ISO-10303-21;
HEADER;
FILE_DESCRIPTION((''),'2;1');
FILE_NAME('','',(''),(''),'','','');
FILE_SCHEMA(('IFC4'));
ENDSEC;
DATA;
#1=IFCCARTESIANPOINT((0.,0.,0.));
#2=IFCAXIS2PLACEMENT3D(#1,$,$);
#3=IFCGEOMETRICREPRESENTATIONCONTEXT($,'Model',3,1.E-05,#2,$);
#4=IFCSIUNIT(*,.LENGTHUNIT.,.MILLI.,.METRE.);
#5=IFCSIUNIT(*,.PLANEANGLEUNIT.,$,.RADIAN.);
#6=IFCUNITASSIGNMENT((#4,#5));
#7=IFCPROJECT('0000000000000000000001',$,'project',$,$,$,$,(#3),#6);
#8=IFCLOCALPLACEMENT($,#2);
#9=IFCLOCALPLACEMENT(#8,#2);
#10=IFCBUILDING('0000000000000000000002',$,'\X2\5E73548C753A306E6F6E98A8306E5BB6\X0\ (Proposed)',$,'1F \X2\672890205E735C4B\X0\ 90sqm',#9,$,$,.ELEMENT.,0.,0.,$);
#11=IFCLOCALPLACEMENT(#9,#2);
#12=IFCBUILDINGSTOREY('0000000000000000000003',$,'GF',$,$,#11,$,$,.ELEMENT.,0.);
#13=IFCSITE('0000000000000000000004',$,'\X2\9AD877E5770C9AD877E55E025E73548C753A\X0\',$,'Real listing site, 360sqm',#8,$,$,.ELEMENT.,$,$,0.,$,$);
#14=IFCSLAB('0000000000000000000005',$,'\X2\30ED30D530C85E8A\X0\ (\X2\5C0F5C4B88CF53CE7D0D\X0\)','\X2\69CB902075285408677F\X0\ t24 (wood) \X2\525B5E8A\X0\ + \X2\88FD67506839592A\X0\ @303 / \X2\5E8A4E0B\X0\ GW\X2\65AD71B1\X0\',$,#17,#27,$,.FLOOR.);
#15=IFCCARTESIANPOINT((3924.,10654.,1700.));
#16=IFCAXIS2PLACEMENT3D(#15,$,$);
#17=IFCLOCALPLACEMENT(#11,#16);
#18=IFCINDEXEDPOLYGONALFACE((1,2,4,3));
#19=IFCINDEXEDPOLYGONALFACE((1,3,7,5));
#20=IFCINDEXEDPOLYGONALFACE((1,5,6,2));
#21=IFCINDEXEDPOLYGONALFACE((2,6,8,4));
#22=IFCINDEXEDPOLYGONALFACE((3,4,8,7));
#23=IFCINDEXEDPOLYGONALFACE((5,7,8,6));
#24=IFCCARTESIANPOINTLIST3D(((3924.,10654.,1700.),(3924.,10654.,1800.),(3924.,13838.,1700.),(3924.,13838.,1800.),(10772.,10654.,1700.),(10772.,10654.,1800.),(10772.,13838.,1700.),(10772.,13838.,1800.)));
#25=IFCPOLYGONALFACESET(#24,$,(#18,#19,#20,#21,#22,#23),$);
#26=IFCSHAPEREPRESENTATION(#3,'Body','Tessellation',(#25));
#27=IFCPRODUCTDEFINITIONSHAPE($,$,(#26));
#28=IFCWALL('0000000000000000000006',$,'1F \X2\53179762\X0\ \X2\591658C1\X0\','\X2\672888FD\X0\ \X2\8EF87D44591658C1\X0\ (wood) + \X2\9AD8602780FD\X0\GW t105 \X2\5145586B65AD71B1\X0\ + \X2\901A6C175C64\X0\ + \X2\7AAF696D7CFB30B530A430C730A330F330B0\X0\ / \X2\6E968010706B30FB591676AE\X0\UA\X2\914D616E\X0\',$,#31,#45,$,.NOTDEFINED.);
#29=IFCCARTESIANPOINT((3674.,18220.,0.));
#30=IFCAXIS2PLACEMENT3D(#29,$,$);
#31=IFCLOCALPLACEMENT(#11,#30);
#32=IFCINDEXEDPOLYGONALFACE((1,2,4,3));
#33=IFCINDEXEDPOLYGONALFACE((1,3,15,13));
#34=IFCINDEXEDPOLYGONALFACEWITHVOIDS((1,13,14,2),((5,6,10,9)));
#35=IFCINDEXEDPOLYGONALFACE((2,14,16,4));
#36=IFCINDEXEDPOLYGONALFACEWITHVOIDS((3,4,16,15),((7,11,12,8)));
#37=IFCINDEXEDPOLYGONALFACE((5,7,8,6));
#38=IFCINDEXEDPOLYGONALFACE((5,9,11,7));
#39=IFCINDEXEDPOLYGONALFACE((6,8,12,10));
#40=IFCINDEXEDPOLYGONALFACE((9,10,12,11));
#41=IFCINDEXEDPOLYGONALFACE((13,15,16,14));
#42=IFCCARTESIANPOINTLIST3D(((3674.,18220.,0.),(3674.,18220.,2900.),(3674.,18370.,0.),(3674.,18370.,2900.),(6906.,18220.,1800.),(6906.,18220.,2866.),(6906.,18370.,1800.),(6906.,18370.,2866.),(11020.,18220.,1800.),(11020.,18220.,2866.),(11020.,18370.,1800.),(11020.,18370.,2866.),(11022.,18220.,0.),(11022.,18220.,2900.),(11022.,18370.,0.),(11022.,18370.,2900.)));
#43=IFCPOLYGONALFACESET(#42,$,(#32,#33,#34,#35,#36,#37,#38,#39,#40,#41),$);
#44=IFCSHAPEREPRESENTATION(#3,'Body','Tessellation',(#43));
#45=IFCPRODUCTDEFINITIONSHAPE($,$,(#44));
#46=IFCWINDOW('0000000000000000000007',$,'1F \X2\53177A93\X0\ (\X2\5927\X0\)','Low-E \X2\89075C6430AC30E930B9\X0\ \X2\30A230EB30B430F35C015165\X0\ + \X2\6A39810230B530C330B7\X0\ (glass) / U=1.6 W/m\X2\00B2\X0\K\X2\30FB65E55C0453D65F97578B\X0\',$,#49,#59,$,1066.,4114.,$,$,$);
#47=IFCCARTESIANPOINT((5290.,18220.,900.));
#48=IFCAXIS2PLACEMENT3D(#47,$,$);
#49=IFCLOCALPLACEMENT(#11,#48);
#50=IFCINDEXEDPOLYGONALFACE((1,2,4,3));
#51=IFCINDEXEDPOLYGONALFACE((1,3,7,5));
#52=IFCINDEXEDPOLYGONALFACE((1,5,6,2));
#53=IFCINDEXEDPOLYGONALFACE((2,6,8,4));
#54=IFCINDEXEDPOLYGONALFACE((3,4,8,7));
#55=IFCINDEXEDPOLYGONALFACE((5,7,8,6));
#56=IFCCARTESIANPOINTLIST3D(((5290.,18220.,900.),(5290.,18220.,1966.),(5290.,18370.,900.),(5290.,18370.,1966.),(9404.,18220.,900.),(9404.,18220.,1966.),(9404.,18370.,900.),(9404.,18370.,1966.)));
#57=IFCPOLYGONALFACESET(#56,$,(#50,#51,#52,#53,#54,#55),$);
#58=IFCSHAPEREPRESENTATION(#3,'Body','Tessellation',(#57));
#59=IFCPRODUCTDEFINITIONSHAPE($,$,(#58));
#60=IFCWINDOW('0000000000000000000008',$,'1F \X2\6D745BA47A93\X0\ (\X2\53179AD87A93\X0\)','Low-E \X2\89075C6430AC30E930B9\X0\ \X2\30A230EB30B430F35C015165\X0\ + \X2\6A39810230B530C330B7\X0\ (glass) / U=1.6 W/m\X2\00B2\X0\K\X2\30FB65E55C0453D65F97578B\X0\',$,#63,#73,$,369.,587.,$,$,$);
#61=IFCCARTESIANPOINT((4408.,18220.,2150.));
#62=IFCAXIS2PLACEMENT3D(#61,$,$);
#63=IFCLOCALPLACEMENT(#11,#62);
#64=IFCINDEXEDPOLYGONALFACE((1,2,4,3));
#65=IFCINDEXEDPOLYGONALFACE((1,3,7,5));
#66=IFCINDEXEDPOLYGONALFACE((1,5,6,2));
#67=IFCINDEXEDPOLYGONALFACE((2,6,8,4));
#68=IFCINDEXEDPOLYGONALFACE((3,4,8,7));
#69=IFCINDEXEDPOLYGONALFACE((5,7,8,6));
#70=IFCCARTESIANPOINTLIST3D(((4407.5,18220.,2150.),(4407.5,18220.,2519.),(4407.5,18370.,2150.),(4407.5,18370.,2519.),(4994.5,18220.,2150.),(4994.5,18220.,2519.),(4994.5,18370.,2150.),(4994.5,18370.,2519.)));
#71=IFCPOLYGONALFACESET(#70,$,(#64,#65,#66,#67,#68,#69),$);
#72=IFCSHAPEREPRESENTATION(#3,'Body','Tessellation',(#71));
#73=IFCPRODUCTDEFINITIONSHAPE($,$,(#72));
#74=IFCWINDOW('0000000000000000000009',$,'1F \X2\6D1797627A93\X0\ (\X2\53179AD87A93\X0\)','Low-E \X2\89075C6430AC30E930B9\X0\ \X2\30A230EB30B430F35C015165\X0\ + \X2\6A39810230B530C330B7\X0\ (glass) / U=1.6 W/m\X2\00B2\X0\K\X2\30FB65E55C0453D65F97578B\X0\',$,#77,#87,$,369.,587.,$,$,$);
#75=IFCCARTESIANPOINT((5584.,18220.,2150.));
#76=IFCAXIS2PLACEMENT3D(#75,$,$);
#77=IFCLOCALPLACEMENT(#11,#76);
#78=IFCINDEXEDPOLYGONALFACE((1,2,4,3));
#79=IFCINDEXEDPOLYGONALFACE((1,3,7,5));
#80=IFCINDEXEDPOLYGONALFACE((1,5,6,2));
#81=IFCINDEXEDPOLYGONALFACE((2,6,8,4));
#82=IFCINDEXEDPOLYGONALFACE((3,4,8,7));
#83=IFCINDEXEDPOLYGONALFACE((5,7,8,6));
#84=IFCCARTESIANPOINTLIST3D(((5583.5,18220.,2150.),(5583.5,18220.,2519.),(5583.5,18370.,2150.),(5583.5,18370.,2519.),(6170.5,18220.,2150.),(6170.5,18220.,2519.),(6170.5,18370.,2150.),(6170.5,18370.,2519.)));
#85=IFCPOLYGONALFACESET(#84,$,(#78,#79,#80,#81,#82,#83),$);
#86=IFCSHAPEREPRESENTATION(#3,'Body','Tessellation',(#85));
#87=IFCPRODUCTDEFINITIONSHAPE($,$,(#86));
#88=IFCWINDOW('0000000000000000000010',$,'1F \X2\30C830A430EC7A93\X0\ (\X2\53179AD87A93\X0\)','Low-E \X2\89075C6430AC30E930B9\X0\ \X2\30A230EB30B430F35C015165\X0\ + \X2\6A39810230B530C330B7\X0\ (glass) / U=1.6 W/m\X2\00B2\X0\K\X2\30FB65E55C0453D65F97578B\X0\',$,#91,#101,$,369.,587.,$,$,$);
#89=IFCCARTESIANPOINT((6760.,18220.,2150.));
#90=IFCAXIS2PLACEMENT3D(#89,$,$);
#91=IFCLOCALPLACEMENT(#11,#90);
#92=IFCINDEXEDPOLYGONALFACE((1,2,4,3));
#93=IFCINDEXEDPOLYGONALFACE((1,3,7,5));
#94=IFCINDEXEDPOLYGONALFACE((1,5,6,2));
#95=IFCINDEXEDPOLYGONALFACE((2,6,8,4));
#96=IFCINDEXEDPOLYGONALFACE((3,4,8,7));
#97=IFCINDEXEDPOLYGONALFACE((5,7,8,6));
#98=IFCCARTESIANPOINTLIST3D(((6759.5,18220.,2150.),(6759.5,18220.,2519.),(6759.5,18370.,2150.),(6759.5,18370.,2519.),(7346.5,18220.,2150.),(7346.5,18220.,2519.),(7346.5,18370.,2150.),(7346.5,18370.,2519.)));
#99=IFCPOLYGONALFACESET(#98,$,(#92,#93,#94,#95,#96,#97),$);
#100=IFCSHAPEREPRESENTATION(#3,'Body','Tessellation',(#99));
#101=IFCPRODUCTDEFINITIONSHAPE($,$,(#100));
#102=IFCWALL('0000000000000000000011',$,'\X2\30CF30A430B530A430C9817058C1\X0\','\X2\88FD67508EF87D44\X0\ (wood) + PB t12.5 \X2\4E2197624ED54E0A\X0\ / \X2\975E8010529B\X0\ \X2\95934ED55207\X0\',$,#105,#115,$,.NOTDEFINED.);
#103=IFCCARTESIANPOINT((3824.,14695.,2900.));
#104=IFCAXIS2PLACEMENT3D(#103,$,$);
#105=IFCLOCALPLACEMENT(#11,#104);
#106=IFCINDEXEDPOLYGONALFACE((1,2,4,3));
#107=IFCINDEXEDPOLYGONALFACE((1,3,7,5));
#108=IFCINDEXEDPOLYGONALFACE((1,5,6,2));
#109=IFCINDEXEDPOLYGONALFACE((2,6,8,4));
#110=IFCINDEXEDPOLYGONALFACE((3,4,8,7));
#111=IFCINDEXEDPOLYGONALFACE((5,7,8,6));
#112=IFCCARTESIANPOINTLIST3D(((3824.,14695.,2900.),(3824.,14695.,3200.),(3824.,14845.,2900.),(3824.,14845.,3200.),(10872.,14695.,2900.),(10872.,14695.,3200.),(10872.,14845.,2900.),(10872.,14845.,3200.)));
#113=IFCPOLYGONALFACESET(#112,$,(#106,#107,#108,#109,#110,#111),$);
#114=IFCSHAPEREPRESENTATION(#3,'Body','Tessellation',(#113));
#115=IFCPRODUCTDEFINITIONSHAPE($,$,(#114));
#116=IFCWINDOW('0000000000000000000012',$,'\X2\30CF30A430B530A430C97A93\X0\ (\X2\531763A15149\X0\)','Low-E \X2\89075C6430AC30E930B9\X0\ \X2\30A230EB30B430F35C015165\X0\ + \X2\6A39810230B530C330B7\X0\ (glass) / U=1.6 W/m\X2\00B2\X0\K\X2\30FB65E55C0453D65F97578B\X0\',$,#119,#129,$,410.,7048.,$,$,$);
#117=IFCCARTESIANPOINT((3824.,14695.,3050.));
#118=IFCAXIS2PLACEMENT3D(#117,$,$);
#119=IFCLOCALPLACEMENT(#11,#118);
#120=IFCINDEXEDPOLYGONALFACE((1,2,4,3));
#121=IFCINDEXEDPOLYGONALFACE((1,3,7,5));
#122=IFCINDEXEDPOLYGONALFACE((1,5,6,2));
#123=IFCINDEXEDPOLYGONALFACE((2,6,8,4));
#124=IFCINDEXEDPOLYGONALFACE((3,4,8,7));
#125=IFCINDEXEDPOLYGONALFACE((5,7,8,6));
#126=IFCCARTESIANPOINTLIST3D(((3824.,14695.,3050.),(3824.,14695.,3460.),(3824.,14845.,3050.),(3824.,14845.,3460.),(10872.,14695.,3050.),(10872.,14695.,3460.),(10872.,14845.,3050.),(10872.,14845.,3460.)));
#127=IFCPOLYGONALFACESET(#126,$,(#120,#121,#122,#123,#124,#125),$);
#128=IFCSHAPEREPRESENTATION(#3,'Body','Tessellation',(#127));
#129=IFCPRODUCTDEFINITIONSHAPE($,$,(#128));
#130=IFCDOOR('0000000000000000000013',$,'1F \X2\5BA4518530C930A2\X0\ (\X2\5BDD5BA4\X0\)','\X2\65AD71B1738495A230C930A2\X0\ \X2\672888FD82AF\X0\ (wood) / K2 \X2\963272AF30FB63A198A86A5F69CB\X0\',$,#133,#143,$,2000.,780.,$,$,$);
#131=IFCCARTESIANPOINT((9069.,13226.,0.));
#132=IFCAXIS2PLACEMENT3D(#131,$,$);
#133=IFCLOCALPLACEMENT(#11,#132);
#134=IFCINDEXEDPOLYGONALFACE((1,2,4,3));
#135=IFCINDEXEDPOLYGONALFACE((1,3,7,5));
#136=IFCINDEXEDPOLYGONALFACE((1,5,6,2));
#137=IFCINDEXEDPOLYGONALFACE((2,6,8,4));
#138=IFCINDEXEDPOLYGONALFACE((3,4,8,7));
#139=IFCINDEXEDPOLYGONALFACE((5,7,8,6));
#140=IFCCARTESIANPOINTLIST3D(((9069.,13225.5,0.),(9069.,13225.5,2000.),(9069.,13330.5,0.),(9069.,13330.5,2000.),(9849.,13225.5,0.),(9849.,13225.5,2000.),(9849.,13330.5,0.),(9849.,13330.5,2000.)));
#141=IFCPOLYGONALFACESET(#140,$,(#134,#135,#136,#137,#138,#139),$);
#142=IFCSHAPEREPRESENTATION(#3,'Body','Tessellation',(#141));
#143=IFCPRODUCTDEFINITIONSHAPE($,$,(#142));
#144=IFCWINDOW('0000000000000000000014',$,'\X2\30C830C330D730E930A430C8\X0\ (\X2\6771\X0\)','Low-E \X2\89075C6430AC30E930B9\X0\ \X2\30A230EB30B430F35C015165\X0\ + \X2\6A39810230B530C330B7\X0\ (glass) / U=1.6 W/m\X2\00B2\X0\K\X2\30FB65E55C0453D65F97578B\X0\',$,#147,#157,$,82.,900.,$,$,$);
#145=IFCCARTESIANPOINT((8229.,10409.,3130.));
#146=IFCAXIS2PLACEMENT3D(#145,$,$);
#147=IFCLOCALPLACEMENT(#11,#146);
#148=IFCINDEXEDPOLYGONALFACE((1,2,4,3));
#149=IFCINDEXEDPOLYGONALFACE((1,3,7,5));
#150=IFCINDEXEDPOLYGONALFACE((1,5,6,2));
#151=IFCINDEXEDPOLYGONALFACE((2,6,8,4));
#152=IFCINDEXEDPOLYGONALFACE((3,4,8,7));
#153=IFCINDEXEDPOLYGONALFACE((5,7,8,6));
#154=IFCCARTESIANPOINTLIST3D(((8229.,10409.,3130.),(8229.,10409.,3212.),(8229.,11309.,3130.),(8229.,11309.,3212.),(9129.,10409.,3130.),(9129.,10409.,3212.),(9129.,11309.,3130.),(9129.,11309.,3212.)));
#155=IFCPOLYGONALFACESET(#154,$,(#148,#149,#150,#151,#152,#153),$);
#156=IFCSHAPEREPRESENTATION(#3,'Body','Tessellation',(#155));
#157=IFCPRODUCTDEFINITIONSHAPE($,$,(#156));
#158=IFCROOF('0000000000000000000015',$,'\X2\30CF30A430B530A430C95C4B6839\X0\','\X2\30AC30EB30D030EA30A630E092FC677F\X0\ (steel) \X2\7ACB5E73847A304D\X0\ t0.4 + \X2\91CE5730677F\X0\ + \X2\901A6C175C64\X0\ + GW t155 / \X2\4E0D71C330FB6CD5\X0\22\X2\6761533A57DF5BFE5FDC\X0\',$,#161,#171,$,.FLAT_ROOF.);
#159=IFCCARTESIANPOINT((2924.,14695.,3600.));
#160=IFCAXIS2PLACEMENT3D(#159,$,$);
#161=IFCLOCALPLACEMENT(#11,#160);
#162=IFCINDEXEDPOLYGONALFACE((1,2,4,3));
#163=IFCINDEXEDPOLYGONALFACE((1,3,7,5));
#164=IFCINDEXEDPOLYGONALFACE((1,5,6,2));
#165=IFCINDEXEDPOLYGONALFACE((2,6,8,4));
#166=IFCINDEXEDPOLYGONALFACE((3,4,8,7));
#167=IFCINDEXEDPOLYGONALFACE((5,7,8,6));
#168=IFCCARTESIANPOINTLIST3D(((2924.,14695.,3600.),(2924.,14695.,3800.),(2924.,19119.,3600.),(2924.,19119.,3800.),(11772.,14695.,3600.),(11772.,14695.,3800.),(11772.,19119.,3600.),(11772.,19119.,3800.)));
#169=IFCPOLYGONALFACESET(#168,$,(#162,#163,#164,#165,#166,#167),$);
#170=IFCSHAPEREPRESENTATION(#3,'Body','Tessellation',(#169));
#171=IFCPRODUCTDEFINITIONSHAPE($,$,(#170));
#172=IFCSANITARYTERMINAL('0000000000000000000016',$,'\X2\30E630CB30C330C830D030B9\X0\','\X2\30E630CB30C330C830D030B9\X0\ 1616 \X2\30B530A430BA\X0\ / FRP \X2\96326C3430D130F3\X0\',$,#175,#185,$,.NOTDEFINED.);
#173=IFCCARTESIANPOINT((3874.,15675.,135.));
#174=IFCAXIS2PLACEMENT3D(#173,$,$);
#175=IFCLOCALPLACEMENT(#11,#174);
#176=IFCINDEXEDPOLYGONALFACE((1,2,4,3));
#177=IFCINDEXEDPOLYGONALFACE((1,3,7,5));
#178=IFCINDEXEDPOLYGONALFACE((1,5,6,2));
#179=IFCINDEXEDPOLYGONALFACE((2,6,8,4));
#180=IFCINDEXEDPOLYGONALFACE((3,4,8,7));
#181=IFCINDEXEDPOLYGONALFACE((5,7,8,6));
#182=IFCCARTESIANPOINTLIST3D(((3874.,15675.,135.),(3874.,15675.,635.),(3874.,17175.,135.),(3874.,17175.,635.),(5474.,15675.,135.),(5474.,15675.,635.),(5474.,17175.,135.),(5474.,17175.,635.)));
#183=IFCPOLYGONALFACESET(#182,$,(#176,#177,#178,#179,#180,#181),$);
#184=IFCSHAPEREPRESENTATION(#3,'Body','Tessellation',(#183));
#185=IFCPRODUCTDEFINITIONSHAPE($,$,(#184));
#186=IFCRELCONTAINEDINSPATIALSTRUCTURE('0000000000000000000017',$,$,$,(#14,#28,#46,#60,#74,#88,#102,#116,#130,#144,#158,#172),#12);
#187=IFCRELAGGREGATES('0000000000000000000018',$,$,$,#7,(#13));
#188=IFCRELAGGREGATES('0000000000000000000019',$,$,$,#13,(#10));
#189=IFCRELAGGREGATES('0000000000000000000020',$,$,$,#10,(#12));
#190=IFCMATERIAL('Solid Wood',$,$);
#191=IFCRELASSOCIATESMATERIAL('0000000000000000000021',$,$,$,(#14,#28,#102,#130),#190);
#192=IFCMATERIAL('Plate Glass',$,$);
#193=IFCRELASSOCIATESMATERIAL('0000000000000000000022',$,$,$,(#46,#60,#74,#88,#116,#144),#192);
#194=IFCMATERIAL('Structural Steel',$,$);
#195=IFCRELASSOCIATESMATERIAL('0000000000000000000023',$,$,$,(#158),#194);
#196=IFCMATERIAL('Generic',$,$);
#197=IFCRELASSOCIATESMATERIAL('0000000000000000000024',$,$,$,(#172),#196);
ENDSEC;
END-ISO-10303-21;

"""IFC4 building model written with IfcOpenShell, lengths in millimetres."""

from ifc_helpers import new_model, si_unit, frame, frame_2d, origin, place, context, project, spatial, rectangle, extrude, material, element, fill, save


model = new_model("IFC4")

# Units and contexts
model_context = context("Model", 3, precision=1e-05, world=origin())
ifc_project = project(units=[si_unit("LENGTHUNIT", "METRE", prefix="MILLI"), si_unit("PLANEANGLEUNIT", "RADIAN")], contexts=[model_context])

# Site, building, storey
site_placement = place(None, origin())
site = spatial("IfcSite", under=ifc_project, at=site_placement, Name="高知県高知市平和町", ObjectType="Real listing site, 360sqm", CompositionType="ELEMENT", RefElevation=0.0)
building_placement = place(site_placement, origin())
building = spatial("IfcBuilding", under=site, at=building_placement, Name="平和町の潮風の家 (Proposed)", ObjectType="1F 木造平屋 90sqm", CompositionType="ELEMENT", ElevationOfRefHeight=0.0, ElevationOfTerrain=0.0)
storey_placement = place(building_placement, origin())
storey = spatial("IfcBuildingStorey", under=building, at=storey_placement, Name="GF", CompositionType="ELEMENT", Elevation=0.0)

# Slab
ifc_material_1 = material(Name="Solid Wood")
slab_placement = place(storey_placement, frame((3924.0, 10654.0, 1700.0)))
element("IfcSlab", 1, at=slab_placement, inside=storey, material=ifc_material_1, Name="ロフト床 (小屋裏収納)", Description="構造用合板 t24 (wood) 剛床 + 製材根太 @303 / 床下 GW断熱", PredefinedType="FLOOR", context=model_context, shape_type="SweptSolid", body=[
    extrude(rectangle(XDim=6848.0, YDim=3184.0, at=frame_2d((3424.0, 1592.0))), frame((3924.0, 10654.0, 1700.0)), (0.0, 0.0, 1.0), 100.0),
])

# Wall, openings, windows
wall_1_placement = place(storey_placement, frame((3674.0, 18220.0, 0.0)))
wall_1 = element("IfcWall", 2, at=wall_1_placement, inside=storey, material=ifc_material_1, Name="1F 北面 外壁", Description="木製 軸組外壁 (wood) + 高性能GW t105 充填断熱 + 通気層 + 窯業系サイディング / 準耐火・外皮UA配慮", PredefinedType="NOTDEFINED", context=model_context, shape_type="SweptSolid", body=[
    extrude(rectangle(XDim=7348.0, YDim=150.0, at=frame_2d((3674.0, 75.0))), frame((3674.0, 18220.0, 0.0)), (0.0, 0.0, 1.0), 2900.0),
])
opening_1_placement = place(storey_placement, frame((5290.0, 18220.0, 900.0)))
opening_1 = element("IfcOpeningElement", 3, at=opening_1_placement, cuts=wall_1, PredefinedType="NOTDEFINED", context=model_context, shape_type="SweptSolid", body=[
    extrude(rectangle(XDim=4114.0, YDim=150.0, at=frame_2d((2057.0, 75.0))), frame((5290.0, 18220.0, 900.0)), (0.0, 0.0, 1.0), 1066.0),
])
opening_2_placement = place(storey_placement, frame((4408.0, 18220.0, 2150.0)))
opening_2 = element("IfcOpeningElement", 4, at=opening_2_placement, cuts=wall_1, PredefinedType="NOTDEFINED", context=model_context, shape_type="SweptSolid", body=[
    extrude(rectangle(XDim=587.0, YDim=150.0, at=frame_2d((293.0, 75.0))), frame((4408.0, 18220.0, 2150.0)), (0.0, 0.0, 1.0), 369.0),
])
opening_3_placement = place(storey_placement, frame((5584.0, 18220.0, 2150.0)))
opening_3 = element("IfcOpeningElement", 5, at=opening_3_placement, cuts=wall_1, PredefinedType="NOTDEFINED", context=model_context, shape_type="SweptSolid", body=[
    extrude(rectangle(XDim=587.0, YDim=150.0, at=frame_2d((293.0, 75.0))), frame((5584.0, 18220.0, 2150.0)), (0.0, 0.0, 1.0), 369.0),
])
opening_4_placement = place(storey_placement, frame((6760.0, 18220.0, 2150.0)))
opening_4 = element("IfcOpeningElement", 6, at=opening_4_placement, cuts=wall_1, PredefinedType="NOTDEFINED", context=model_context, shape_type="SweptSolid", body=[
    extrude(rectangle(XDim=587.0, YDim=150.0, at=frame_2d((293.0, 75.0))), frame((6760.0, 18220.0, 2150.0)), (0.0, 0.0, 1.0), 369.0),
])
ifc_material_2 = material(Name="Plate Glass")
window_1_placement = place(storey_placement, frame((5290.0, 18220.0, 900.0)))
window_1 = element("IfcWindow", 7, at=window_1_placement, inside=storey, material=ifc_material_2, Name="1F 北窓 (大)", Description="Low-E 複層ガラス アルゴン封入 + 樹脂サッシ (glass) / U=1.6 W/m²K・日射取得型", OverallHeight=1066.0, OverallWidth=4114.0, context=model_context, shape_type="SweptSolid", body=[
    extrude(rectangle(XDim=4114.0, YDim=150.0, at=frame_2d((2057.0, 75.0))), frame((5290.0, 18220.0, 900.0)), (0.0, 0.0, 1.0), 1066.0),
])
fill(opening_1, window_1)
window_2_placement = place(storey_placement, frame((4408.0, 18220.0, 2150.0)))
window_2 = element("IfcWindow", 8, at=window_2_placement, inside=storey, material=ifc_material_2, Name="1F 浴室窓 (北高窓)", Description="Low-E 複層ガラス アルゴン封入 + 樹脂サッシ (glass) / U=1.6 W/m²K・日射取得型", OverallHeight=369.0, OverallWidth=587.0, context=model_context, shape_type="SweptSolid", body=[
    extrude(rectangle(XDim=587.0, YDim=150.0, at=frame_2d((293.0, 75.0))), frame((4408.0, 18220.0, 2150.0)), (0.0, 0.0, 1.0), 369.0),
])
fill(opening_2, window_2)
window_3_placement = place(storey_placement, frame((5584.0, 18220.0, 2150.0)))
window_3 = element("IfcWindow", 9, at=window_3_placement, inside=storey, material=ifc_material_2, Name="1F 洗面窓 (北高窓)", Description="Low-E 複層ガラス アルゴン封入 + 樹脂サッシ (glass) / U=1.6 W/m²K・日射取得型", OverallHeight=369.0, OverallWidth=587.0, context=model_context, shape_type="SweptSolid", body=[
    extrude(rectangle(XDim=587.0, YDim=150.0, at=frame_2d((293.0, 75.0))), frame((5584.0, 18220.0, 2150.0)), (0.0, 0.0, 1.0), 369.0),
])
fill(opening_3, window_3)
window_4_placement = place(storey_placement, frame((6760.0, 18220.0, 2150.0)))
window_4 = element("IfcWindow", 10, at=window_4_placement, inside=storey, material=ifc_material_2, Name="1F トイレ窓 (北高窓)", Description="Low-E 複層ガラス アルゴン封入 + 樹脂サッシ (glass) / U=1.6 W/m²K・日射取得型", OverallHeight=369.0, OverallWidth=587.0, context=model_context, shape_type="SweptSolid", body=[
    extrude(rectangle(XDim=587.0, YDim=150.0, at=frame_2d((293.0, 75.0))), frame((6760.0, 18220.0, 2150.0)), (0.0, 0.0, 1.0), 369.0),
])
fill(opening_4, window_4)

# Wall, opening, window
wall_2_placement = place(storey_placement, frame((3824.0, 14695.0, 2900.0)))
wall_2 = element("IfcWall", 11, at=wall_2_placement, inside=storey, material=ifc_material_1, Name="ハイサイド腰壁", Description="製材軸組 (wood) + PB t12.5 両面仕上 / 非耐力 間仕切", PredefinedType="NOTDEFINED", context=model_context, shape_type="SweptSolid", body=[
    extrude(rectangle(XDim=7048.0, YDim=150.0, at=frame_2d((3524.0, 75.0))), frame((3824.0, 14695.0, 2900.0)), (0.0, 0.0, 1.0), 700.0),
])
opening_5_placement = place(storey_placement, frame((3824.0, 14695.0, 3050.0)))
opening_5 = element("IfcOpeningElement", 12, at=opening_5_placement, cuts=wall_2, PredefinedType="NOTDEFINED", context=model_context, shape_type="SweptSolid", body=[
    extrude(rectangle(XDim=7048.0, YDim=150.0, at=frame_2d((3524.0, 75.0))), frame((3824.0, 14695.0, 3050.0)), (0.0, 0.0, 1.0), 410.0),
])
window_5_placement = place(storey_placement, frame((3824.0, 14695.0, 3050.0)))
window_5 = element("IfcWindow", 13, at=window_5_placement, inside=storey, material=ifc_material_2, Name="ハイサイド窓 (北採光)", Description="Low-E 複層ガラス アルゴン封入 + 樹脂サッシ (glass) / U=1.6 W/m²K・日射取得型", OverallHeight=410.0, OverallWidth=7048.0, context=model_context, shape_type="SweptSolid", body=[
    extrude(rectangle(XDim=7048.0, YDim=150.0, at=frame_2d((3524.0, 75.0))), frame((3824.0, 14695.0, 3050.0)), (0.0, 0.0, 1.0), 410.0),
])
fill(opening_5, window_5)

# Door
door_1_placement = place(storey_placement, frame((9069.0, 13226.0, 0.0)))
element("IfcDoor", 14, at=door_1_placement, inside=storey, material=ifc_material_1, Name="1F 室内ドア (寝室)", Description="断熱玄関ドア 木製芯 (wood) / K2 防犯・採風機構", OverallHeight=2000.0, OverallWidth=780.0, context=model_context, shape_type="SweptSolid", body=[
    extrude(rectangle(XDim=780.0, YDim=105.0, at=frame_2d((390.0, 52.0))), frame((9069.0, 13226.0, 0.0)), (0.0, 0.0, 1.0), 2000.0),
])

# Window
window_6_placement = place(storey_placement, frame((8229.0, 10409.0, 3130.0)))
element("IfcWindow", 15, at=window_6_placement, inside=storey, material=ifc_material_2, Name="トップライト (東)", Description="Low-E 複層ガラス アルゴン封入 + 樹脂サッシ (glass) / U=1.6 W/m²K・日射取得型", OverallHeight=82.0, OverallWidth=900.0, context=model_context, shape_type="SweptSolid", body=[
    extrude(rectangle(XDim=900.0, YDim=900.0, at=frame_2d((450.0, 450.0))), frame((8229.0, 10409.0, 3130.0)), (0.0, 0.0, 1.0), 82.0),
])

# Roof
ifc_material_3 = material(Name="Structural Steel")
roof_placement = place(storey_placement, frame((2924.0, 14695.0, 3600.0)))
element("IfcRoof", 16, at=roof_placement, inside=storey, material=ifc_material_3, Name="ハイサイド屋根", Description="ガルバリウム鋼板 (steel) 立平葺き t0.4 + 野地板 + 通気層 + GW t155 / 不燃・法22条区域対応", PredefinedType="FLAT_ROOF", context=model_context, shape_type="SweptSolid", body=[
    extrude(rectangle(XDim=8848.0, YDim=4424.0, at=frame_2d((4424.0, 2212.0))), frame((2924.0, 14695.0, 3600.0)), (0.0, 0.0, 1.0), 200.0),
])

# Sanitary terminal
ifc_material_4 = material(Name="Generic")
sanitary_terminal_1_placement = place(storey_placement, frame((3874.0, 15675.0, 135.0)))
element("IfcSanitaryTerminal", 17, at=sanitary_terminal_1_placement, inside=storey, material=ifc_material_4, Name="ユニットバス", Description="ユニットバス 1616 サイズ / FRP 防水パン", PredefinedType="NOTDEFINED", context=model_context, shape_type="SweptSolid", body=[
    extrude(rectangle(XDim=1600.0, YDim=1500.0, at=frame_2d((800.0, 750.0))), frame((3874.0, 15675.0, 135.0)), (0.0, 0.0, 1.0), 500.0),
])

save(model, "model.ifc")
